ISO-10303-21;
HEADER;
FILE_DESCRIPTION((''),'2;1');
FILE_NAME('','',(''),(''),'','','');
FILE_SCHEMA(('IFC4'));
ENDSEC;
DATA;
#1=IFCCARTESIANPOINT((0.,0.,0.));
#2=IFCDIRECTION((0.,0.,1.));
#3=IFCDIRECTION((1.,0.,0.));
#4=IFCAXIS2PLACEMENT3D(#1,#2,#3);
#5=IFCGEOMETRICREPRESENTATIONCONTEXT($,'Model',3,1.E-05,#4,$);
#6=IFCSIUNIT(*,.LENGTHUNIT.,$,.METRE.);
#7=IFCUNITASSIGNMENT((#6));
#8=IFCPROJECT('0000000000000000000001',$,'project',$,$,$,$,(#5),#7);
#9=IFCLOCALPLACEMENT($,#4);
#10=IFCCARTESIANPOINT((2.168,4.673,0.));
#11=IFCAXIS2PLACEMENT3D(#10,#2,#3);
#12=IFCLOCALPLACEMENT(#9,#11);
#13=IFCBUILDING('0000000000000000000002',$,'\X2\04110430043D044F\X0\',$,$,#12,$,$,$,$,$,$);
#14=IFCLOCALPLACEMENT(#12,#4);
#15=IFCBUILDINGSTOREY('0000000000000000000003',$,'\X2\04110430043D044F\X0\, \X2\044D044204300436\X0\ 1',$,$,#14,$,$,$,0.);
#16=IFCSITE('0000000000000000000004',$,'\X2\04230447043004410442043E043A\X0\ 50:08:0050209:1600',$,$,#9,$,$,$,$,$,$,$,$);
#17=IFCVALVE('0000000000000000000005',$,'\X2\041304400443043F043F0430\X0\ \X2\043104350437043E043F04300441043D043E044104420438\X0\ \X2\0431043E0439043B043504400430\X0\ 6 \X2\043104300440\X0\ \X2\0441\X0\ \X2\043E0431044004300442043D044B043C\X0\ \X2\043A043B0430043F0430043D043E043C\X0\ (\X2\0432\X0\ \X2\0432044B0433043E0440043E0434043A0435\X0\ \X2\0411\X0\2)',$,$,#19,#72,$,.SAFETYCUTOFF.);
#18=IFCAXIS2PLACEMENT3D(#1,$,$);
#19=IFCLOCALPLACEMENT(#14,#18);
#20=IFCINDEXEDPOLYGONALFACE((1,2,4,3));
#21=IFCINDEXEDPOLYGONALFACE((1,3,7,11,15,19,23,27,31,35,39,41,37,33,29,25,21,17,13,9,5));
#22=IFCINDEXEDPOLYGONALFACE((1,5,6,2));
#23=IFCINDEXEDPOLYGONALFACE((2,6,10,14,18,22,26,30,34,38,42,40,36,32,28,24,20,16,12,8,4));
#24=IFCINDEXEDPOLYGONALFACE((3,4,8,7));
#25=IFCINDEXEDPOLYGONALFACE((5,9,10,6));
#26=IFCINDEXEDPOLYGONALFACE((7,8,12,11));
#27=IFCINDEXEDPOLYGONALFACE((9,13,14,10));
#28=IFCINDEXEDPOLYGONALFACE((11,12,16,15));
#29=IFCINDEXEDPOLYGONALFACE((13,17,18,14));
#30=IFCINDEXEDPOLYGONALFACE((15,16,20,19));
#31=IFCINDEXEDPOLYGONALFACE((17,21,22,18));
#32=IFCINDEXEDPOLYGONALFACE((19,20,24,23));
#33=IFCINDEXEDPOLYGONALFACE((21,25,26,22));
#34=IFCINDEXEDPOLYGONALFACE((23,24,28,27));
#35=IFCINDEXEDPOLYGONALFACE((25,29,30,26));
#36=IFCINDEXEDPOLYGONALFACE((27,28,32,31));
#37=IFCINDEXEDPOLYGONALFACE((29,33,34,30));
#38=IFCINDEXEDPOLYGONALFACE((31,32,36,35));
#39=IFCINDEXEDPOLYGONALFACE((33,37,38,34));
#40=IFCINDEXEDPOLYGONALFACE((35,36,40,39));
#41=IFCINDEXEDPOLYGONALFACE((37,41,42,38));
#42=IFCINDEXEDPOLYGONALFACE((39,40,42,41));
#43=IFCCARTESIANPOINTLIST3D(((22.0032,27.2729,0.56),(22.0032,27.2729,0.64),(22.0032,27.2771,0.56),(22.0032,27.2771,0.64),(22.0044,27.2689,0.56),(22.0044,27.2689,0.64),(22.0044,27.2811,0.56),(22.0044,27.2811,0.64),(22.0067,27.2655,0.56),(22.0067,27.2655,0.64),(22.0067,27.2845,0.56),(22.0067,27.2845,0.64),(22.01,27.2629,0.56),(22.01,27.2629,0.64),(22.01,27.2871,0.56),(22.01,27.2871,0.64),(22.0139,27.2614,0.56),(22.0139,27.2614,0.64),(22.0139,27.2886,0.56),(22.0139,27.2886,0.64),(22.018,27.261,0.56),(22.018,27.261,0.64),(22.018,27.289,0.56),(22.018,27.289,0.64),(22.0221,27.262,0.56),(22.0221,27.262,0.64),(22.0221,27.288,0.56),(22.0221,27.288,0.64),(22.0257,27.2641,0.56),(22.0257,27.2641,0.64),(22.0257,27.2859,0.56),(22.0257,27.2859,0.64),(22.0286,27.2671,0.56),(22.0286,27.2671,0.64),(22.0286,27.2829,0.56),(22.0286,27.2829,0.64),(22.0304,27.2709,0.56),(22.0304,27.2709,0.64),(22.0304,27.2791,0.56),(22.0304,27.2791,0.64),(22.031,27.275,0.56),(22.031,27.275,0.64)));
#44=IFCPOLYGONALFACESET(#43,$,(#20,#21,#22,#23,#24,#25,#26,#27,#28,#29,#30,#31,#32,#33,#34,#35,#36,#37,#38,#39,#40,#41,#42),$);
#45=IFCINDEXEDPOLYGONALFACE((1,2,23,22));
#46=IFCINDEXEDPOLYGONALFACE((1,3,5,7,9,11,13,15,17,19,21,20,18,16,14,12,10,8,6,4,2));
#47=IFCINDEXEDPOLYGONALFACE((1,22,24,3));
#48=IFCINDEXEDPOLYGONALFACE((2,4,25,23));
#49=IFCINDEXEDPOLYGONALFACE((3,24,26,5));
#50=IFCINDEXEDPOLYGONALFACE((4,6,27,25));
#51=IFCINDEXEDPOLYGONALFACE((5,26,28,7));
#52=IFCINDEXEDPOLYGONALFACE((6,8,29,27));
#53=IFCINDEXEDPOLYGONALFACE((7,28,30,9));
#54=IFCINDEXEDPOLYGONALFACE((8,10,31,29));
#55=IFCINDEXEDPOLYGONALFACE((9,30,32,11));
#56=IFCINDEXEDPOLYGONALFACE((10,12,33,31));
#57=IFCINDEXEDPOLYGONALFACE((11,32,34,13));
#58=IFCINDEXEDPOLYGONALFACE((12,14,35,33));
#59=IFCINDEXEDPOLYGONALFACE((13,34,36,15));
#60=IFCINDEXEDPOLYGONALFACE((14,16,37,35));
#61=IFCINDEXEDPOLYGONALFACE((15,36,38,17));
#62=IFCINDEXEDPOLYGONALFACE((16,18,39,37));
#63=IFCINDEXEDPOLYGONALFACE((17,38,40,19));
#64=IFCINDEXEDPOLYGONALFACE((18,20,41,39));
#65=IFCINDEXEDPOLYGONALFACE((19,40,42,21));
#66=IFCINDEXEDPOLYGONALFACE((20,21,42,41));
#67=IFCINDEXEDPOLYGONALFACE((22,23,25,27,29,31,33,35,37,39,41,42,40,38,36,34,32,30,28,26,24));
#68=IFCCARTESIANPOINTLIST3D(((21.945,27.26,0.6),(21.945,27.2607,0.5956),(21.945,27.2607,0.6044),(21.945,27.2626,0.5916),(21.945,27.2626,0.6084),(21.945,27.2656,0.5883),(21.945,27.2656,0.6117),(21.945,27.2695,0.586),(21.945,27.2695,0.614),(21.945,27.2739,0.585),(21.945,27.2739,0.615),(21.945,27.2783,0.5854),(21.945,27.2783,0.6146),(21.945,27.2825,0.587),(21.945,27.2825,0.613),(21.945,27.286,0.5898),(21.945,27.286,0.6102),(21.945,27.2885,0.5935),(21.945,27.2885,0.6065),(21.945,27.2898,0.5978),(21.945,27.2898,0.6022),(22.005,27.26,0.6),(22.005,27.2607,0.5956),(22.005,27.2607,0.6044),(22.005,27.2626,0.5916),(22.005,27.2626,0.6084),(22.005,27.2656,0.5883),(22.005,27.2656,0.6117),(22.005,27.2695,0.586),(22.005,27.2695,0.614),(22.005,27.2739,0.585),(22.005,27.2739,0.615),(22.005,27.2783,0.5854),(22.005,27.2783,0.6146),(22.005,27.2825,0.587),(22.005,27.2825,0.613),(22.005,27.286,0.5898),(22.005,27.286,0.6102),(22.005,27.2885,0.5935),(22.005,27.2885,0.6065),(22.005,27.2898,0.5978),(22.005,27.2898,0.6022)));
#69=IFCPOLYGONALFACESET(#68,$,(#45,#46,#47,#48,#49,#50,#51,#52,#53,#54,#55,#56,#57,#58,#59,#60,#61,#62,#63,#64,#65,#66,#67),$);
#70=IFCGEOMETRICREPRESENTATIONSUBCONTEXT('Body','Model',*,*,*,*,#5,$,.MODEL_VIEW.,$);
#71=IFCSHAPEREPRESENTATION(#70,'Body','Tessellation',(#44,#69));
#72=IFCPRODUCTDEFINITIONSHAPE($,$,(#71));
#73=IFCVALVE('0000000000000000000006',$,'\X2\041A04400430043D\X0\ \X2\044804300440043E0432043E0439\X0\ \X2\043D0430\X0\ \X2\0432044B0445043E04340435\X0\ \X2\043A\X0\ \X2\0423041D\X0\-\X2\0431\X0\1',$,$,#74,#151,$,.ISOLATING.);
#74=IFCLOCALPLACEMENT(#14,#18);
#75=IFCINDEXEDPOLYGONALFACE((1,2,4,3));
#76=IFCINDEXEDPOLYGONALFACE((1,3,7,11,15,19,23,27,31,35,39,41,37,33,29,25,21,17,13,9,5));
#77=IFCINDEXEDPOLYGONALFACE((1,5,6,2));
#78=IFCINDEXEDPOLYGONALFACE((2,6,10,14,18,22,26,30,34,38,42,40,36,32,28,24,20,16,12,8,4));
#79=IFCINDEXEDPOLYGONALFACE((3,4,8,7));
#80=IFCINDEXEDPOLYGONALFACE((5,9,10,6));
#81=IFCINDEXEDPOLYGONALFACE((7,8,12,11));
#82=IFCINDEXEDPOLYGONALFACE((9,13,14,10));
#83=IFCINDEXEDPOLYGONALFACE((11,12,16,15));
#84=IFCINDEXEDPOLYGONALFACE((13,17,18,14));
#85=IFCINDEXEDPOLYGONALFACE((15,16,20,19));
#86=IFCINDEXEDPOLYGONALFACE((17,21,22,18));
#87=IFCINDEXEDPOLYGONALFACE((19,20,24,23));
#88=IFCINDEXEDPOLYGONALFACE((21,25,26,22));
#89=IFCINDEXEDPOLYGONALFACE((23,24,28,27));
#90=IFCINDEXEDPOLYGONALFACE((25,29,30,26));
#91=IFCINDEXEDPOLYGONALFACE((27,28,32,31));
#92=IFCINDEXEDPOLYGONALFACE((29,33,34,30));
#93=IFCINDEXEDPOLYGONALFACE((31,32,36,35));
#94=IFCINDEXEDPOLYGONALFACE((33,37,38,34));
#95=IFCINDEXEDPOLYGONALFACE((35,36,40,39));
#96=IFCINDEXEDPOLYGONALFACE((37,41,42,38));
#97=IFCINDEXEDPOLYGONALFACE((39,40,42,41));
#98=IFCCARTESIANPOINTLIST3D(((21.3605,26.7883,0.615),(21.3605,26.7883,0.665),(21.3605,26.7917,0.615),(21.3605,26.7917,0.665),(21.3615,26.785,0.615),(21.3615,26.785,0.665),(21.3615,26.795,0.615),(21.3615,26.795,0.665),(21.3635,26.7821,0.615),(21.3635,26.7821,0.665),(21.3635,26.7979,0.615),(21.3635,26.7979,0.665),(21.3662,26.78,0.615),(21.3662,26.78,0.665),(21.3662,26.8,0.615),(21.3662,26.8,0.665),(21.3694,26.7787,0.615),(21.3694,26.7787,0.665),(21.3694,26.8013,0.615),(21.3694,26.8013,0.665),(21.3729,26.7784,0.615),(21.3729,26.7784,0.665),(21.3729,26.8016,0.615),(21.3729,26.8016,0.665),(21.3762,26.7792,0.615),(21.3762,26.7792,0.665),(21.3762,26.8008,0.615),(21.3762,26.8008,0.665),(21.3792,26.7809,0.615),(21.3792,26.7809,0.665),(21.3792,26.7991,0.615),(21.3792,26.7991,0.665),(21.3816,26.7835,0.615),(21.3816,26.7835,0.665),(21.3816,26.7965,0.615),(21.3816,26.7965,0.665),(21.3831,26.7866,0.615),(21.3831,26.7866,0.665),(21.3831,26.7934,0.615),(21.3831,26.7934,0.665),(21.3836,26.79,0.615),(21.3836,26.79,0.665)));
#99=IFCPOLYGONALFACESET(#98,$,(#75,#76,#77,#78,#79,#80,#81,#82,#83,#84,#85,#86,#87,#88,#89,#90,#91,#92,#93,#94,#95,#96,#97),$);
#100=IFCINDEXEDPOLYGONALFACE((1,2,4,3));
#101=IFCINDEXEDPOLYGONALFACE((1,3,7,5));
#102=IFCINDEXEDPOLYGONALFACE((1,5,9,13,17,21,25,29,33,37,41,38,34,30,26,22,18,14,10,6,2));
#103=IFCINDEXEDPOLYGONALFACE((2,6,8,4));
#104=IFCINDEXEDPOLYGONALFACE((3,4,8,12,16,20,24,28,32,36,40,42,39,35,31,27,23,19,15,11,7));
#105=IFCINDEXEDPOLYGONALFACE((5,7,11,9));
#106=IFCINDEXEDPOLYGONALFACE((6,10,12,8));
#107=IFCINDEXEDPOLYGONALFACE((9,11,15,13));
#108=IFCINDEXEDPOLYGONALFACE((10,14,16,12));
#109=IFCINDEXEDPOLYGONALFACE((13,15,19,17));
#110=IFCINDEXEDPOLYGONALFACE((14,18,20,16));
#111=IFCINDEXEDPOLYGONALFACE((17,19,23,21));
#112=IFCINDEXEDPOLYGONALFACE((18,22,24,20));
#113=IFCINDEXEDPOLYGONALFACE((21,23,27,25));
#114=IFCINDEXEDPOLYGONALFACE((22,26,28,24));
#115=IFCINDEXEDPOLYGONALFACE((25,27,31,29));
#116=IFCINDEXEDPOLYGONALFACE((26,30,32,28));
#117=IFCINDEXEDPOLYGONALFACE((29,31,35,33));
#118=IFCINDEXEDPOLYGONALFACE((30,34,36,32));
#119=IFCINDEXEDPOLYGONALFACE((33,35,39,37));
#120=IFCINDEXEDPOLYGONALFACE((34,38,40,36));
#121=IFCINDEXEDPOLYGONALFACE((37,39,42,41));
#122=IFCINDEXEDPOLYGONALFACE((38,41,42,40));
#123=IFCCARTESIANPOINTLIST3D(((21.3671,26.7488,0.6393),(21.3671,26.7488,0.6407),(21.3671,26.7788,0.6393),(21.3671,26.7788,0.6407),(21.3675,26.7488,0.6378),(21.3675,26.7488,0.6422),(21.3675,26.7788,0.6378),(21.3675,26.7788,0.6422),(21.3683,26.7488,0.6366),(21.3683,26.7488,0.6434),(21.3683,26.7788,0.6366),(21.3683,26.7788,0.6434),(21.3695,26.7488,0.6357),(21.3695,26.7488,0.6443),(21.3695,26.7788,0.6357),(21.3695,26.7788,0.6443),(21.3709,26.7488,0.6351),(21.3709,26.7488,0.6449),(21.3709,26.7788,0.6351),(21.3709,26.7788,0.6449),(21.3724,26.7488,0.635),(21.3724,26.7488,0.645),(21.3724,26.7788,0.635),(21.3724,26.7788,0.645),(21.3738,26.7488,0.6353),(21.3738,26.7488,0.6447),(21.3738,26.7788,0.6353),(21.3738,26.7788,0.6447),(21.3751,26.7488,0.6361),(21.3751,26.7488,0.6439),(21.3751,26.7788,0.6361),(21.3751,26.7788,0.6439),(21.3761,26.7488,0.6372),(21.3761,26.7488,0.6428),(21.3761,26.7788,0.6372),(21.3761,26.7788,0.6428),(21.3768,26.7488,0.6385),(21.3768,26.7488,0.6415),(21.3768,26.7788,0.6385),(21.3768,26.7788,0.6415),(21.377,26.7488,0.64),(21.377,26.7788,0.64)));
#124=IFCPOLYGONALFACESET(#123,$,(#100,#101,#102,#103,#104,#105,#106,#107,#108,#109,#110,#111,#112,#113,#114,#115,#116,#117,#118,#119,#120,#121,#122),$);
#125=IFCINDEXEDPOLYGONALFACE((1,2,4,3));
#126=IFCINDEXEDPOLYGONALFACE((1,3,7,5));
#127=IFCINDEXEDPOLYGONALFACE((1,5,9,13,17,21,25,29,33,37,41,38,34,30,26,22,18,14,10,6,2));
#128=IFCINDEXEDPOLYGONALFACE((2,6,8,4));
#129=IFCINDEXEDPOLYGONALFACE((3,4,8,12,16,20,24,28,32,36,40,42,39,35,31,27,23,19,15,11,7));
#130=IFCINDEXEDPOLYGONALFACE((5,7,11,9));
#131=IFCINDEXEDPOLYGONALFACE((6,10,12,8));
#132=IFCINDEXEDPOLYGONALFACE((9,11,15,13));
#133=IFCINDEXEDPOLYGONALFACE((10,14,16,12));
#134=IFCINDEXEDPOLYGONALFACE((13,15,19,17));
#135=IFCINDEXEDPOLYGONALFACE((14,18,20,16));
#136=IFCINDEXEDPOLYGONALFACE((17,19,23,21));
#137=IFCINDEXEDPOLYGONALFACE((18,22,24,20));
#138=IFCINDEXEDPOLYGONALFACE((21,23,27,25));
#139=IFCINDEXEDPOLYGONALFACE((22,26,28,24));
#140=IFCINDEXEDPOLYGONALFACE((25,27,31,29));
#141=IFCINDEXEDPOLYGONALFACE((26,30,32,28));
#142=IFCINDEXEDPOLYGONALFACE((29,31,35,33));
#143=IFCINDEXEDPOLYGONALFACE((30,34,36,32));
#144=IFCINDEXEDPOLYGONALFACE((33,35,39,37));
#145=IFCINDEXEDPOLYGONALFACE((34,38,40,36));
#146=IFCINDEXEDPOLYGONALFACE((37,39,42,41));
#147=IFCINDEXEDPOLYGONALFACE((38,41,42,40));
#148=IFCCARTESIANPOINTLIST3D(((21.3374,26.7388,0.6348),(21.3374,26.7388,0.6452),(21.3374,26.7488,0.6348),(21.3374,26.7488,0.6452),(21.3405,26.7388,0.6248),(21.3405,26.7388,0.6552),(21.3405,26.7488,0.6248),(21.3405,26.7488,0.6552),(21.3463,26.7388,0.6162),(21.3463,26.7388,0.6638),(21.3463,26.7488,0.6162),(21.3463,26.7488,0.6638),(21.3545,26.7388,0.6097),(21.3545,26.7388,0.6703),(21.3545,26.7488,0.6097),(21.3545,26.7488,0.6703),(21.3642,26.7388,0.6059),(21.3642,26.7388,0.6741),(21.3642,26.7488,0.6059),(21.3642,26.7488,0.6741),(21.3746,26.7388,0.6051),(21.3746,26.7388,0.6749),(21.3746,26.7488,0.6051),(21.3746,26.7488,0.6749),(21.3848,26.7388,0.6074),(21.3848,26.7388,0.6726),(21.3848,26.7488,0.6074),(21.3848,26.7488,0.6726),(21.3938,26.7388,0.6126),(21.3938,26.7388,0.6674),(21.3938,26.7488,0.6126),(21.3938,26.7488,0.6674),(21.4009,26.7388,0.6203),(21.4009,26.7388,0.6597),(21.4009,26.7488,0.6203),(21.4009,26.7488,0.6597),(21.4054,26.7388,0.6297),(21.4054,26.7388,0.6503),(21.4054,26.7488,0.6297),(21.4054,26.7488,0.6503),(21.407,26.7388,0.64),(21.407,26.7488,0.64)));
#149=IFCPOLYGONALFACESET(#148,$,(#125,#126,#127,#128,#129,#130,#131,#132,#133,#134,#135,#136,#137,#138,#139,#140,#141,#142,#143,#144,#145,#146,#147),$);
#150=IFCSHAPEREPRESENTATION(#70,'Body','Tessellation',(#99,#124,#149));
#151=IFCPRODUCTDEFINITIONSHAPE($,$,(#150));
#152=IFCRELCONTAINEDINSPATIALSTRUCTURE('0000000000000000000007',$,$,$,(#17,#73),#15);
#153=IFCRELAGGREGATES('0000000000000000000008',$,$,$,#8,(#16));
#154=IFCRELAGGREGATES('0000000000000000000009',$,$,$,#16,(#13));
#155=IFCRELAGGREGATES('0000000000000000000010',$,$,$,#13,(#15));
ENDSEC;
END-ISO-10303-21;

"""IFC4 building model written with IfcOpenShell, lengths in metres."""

from ifc_helpers import new_model, si_unit, frame, origin_with_axes, origin_2d, place, context, subcontext, project, spatial, circle, extrude, element, save


model = new_model("IFC4")

# Units and contexts
model_context = context("Model", 3, precision=1e-05, world=origin_with_axes())
body_context = subcontext(model_context, "Body", "Model", "MODEL_VIEW")
ifc_project = project(units=[si_unit("LENGTHUNIT", "METRE")], contexts=[model_context])

# Site, building, storey
site_placement = place(None, origin_with_axes())
site = spatial("IfcSite", under=ifc_project, at=site_placement, Name="Участок 50:08:0050209:1600")
building_placement = place(site_placement, frame((2.168, 4.673, 0.0), z_axis=(0.0, 0.0, 1.0), x_axis=(1.0, 0.0, 0.0)))
building = spatial("IfcBuilding", under=site, at=building_placement, Name="Баня")
storey_placement = place(building_placement, origin_with_axes())
storey = spatial("IfcBuildingStorey", under=building, at=storey_placement, Name="Баня, этаж 1", Elevation=0.0)

# Valves
valve_1_placement = place(storey_placement, origin_with_axes())
element("IfcValve", 1, at=valve_1_placement, inside=storey, Name="Группа безопасности бойлера 6 бар с обратным клапаном (в выгородке Б2)", PredefinedType="SAFETYCUTOFF", context=body_context, shape_type="SweptSolid", body=[
    extrude(circle(Radius=0.014, at=origin_2d()), frame((22.017, 27.275, 0.56), z_axis=(0.0, 0.0, 1.0), x_axis=(1.0, 0.0, 0.0)), (0.0, 0.0, 1.0), 0.08),
    extrude(circle(Radius=0.015, at=origin_2d()), frame((22.005, 27.275, 0.6), z_axis=(-1.0, 0.0, 0.0), x_axis=(0.0, -1.0, 0.0)), (0.0, 0.0, 1.0), 0.06),
])
valve_2_placement = place(storey_placement, origin_with_axes())
element("IfcValve", 2, at=valve_2_placement, inside=storey, Name="Кран шаровой на выходе к УН-б1", PredefinedType="ISOLATING", context=body_context, shape_type="SweptSolid", body=[
    extrude(circle(Radius=0.0116, at=origin_2d()), frame((21.372, 26.79, 0.615), z_axis=(0.0, 0.0, 1.0), x_axis=(1.0, 0.0, 0.0)), (0.0, 0.0, 1.0), 0.05),
    extrude(circle(Radius=0.005, at=origin_2d()), frame((21.372, 26.7788, 0.64), z_axis=(0.0, -1.0, 0.0), x_axis=(1.0, 0.0, 0.0)), (0.0, 0.0, 1.0), 0.03),
    extrude(circle(Radius=0.035, at=origin_2d()), frame((21.372, 26.7488, 0.64), z_axis=(0.0, -1.0, 0.0), x_axis=(1.0, 0.0, 0.0)), (0.0, 0.0, 1.0), 0.01),
])

save(model, "model.ifc")
